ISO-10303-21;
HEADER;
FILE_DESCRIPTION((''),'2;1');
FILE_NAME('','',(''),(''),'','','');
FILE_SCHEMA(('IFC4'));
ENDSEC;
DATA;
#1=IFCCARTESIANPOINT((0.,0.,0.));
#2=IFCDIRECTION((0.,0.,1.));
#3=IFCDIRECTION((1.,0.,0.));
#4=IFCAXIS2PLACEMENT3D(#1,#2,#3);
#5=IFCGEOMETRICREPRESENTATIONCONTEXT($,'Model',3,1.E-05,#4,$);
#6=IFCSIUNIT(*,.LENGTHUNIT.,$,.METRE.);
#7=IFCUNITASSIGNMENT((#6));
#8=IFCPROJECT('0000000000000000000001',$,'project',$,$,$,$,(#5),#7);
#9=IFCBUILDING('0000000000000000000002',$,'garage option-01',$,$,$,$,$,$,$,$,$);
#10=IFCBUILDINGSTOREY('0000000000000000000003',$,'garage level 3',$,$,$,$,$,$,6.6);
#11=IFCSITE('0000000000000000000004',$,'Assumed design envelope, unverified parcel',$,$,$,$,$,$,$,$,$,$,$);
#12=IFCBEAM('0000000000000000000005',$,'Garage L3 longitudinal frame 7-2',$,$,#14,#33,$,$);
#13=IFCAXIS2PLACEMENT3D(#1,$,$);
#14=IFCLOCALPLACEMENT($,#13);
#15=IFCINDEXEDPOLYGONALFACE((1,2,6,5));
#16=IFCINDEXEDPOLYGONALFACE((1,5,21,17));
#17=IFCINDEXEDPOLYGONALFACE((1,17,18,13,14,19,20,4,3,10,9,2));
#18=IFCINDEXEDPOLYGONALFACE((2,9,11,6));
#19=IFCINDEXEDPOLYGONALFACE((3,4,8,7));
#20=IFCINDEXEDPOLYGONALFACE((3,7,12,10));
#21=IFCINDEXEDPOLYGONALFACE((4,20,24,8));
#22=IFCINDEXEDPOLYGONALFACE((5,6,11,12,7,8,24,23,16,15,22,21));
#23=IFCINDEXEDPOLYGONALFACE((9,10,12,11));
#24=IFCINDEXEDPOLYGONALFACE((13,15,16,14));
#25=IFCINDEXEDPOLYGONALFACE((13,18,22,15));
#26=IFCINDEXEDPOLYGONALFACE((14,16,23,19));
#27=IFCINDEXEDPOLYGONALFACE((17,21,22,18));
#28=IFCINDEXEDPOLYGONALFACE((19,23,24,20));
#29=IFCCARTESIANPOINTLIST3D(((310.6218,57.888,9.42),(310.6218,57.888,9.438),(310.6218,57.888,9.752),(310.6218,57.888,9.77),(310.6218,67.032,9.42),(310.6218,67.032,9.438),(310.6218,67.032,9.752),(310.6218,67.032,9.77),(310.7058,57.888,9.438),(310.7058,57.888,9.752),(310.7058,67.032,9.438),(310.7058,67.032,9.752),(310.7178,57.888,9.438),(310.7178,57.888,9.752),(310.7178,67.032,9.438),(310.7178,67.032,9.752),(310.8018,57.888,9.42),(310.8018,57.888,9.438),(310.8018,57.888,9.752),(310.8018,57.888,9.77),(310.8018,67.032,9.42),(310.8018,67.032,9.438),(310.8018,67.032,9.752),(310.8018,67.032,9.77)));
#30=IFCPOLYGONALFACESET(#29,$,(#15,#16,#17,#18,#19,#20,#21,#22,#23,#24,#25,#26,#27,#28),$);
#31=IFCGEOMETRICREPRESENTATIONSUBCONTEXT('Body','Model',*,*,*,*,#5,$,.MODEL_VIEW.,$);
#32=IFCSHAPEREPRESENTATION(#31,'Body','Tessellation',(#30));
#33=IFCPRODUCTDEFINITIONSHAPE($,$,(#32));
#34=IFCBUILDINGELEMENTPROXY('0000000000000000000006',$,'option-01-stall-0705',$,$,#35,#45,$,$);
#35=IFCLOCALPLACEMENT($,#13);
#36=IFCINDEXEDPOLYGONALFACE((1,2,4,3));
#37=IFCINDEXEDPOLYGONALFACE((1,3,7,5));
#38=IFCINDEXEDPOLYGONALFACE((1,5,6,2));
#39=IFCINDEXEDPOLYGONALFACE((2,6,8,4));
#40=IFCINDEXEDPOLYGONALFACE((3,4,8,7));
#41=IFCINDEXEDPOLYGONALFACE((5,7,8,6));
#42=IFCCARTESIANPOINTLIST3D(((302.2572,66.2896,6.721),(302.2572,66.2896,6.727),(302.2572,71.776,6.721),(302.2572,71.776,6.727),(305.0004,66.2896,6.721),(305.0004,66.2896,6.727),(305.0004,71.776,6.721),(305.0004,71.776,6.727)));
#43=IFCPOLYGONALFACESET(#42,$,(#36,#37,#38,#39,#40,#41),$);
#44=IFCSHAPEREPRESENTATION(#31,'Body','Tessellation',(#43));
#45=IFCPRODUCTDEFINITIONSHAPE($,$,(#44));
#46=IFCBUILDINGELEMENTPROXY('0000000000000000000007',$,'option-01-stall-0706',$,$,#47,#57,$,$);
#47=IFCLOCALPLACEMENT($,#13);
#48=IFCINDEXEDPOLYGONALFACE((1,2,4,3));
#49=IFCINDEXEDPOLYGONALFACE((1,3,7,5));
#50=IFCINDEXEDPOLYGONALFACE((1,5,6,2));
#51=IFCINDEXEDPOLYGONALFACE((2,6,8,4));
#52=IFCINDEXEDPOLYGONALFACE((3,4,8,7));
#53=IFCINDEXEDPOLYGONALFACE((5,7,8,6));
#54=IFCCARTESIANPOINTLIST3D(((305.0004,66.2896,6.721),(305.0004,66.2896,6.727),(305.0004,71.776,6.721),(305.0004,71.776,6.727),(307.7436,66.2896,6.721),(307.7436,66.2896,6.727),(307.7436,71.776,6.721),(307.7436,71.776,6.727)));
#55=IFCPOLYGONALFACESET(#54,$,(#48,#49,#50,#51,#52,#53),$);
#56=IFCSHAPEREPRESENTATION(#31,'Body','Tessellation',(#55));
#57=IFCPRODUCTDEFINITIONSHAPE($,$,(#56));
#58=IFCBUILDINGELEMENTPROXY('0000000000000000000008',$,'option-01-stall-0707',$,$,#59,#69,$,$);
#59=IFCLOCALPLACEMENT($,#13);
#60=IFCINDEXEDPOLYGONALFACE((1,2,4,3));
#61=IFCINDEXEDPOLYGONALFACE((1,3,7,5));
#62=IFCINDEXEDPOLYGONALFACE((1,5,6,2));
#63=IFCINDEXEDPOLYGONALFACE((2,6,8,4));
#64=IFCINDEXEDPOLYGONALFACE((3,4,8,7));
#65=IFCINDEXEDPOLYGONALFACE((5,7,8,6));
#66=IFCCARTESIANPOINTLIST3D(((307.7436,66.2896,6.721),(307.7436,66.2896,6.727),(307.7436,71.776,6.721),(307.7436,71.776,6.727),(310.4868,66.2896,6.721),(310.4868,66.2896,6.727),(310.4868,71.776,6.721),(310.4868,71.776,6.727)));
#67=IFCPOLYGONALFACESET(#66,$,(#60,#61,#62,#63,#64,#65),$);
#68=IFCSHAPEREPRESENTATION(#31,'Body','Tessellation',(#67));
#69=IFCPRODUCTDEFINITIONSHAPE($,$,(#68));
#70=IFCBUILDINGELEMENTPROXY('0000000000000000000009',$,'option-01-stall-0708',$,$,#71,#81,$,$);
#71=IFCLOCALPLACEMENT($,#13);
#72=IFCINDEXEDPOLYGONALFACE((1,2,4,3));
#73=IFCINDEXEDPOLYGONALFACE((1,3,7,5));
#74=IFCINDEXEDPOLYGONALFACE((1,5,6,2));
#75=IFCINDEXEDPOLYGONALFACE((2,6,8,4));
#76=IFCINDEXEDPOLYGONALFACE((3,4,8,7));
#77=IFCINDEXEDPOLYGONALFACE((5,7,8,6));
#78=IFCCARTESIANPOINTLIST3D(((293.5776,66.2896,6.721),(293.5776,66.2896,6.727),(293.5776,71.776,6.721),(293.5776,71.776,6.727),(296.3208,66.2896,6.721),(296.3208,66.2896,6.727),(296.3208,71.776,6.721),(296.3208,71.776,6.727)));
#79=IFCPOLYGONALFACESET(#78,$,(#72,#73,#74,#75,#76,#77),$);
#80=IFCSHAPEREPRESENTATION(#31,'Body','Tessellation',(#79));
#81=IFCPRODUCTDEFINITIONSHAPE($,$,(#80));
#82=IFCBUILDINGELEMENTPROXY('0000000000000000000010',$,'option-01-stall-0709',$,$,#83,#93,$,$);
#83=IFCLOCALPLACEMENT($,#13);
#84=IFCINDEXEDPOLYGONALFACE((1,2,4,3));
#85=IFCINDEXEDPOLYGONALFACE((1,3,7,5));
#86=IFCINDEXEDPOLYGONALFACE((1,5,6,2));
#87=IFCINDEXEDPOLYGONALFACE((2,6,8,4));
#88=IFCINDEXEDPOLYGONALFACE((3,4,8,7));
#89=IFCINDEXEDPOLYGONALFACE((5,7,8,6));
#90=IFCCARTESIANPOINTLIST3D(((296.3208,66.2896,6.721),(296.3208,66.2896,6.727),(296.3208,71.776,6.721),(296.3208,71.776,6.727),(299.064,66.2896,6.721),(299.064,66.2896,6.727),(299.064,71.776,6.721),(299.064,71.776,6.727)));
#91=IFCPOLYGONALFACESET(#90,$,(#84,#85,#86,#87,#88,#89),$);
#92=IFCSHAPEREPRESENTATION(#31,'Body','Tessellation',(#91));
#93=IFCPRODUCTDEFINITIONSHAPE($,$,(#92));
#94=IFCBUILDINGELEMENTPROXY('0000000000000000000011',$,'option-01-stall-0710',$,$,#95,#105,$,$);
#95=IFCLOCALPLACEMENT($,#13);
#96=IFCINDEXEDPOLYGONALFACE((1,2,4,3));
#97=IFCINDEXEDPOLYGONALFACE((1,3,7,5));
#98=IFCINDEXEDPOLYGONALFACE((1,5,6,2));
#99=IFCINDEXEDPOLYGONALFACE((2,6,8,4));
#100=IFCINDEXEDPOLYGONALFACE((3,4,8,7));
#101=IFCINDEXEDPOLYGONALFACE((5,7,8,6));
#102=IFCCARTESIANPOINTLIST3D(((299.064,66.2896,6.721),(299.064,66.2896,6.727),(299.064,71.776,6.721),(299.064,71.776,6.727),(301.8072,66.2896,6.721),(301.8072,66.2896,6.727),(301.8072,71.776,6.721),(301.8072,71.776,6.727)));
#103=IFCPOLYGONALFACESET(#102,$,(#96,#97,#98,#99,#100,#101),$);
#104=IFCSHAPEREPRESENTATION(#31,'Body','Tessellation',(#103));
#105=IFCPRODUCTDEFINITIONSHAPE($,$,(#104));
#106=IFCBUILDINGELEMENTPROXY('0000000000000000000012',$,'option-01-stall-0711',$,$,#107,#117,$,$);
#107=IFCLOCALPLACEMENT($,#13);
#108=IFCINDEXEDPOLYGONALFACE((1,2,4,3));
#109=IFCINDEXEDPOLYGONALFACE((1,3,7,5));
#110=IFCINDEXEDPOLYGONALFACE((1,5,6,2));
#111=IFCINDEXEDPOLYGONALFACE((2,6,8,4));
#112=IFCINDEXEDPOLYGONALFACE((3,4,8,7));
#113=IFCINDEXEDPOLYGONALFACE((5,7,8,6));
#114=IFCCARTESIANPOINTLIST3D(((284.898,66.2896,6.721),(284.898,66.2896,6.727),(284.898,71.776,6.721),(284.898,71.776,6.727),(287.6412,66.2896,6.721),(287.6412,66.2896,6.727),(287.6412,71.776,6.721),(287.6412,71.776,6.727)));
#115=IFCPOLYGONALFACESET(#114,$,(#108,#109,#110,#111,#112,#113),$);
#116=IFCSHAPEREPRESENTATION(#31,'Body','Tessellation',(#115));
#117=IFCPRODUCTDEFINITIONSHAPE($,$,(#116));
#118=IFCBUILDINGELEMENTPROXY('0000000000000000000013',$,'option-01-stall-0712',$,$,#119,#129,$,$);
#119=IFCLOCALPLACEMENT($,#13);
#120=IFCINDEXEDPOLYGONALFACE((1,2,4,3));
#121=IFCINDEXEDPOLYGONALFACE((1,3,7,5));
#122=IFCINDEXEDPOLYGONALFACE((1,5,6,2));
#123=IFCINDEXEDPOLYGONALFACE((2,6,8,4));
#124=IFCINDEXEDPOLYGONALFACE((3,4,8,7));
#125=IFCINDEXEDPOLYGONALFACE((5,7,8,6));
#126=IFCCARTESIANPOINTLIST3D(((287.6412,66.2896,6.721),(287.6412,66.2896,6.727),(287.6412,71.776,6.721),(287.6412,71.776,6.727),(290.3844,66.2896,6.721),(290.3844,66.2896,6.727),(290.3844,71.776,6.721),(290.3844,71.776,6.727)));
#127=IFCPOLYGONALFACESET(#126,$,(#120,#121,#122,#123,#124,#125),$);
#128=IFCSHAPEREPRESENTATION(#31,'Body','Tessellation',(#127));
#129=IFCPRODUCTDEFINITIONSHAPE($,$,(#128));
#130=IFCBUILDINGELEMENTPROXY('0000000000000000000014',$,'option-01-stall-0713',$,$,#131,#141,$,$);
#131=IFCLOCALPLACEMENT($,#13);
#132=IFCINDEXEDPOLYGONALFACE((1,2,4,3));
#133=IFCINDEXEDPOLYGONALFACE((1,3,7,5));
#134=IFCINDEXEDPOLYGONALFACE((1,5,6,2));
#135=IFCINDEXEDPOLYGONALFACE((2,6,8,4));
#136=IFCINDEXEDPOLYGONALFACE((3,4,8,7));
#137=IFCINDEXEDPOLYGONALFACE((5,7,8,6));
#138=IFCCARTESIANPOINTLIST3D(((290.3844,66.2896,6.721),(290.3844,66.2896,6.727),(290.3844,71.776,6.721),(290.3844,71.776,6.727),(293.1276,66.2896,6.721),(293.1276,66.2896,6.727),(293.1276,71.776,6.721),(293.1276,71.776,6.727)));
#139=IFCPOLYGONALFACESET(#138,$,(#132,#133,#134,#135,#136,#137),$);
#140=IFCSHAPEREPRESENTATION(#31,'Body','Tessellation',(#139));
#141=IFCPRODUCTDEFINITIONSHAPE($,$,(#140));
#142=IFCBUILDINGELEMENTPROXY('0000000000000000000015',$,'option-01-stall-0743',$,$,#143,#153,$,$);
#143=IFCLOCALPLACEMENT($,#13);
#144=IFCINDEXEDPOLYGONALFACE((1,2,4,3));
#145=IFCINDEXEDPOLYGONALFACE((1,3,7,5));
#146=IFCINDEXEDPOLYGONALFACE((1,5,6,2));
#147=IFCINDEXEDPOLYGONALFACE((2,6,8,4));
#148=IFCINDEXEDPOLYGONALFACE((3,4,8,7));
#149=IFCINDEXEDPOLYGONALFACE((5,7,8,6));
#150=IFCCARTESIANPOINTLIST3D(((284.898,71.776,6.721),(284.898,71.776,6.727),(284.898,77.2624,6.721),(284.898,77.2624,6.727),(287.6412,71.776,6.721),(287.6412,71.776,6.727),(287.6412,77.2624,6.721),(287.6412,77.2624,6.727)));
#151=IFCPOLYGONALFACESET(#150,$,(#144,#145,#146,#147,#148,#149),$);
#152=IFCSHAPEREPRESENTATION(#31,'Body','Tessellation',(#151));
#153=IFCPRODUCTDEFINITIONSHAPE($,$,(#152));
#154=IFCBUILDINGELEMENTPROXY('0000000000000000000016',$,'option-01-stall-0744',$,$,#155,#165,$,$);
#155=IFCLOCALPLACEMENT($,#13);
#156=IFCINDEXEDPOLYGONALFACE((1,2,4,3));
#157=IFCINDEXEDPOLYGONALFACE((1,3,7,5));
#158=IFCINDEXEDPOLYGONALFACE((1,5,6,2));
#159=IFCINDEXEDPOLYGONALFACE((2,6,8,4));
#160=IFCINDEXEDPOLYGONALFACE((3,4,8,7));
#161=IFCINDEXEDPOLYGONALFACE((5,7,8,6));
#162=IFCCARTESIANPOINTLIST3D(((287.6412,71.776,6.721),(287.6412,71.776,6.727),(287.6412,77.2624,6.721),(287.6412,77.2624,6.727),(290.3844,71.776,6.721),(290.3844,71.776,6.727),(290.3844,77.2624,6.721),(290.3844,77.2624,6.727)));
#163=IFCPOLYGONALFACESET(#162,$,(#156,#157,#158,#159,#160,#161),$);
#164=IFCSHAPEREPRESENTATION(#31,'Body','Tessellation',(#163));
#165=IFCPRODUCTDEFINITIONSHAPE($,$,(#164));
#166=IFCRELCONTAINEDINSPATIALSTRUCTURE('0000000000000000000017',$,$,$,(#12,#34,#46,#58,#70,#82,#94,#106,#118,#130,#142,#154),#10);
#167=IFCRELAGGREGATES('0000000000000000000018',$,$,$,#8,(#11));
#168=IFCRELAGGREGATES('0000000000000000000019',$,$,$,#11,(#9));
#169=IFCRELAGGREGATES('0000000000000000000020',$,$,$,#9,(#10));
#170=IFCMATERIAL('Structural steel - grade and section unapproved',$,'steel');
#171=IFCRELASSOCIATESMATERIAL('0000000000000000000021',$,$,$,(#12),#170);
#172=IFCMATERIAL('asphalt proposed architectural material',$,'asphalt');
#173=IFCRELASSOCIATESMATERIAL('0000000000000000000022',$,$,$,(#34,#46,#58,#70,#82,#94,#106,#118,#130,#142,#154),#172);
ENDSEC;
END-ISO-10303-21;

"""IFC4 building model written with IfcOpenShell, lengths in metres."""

from ifc_helpers import new_model, si_unit, frame, origin_with_axes, place, context, subcontext, project, spatial, rectangle, i_section, extrude, material, element, save


model = new_model("IFC4")

# Units and contexts
model_context = context("Model", 3, precision=1e-05, world=origin_with_axes())
body_context = subcontext(model_context, "Body", "Model", "MODEL_VIEW")
ifc_project = project(units=[si_unit("LENGTHUNIT", "METRE")], contexts=[model_context])

# Site, building, storey
site = spatial("IfcSite", under=ifc_project, Name="Assumed design envelope, unverified parcel")
building = spatial("IfcBuilding", under=site, Name="garage option-01")
storey = spatial("IfcBuildingStorey", under=building, Name="garage level 3", Elevation=6.6)

# Beam
ifc_material_1 = material(Name="Structural steel - grade and section unapproved", Category="steel")
beam_1_placement = place(None, frame((310.7118, 57.888, 9.595), z_axis=(0.0, 1.0, 0.0), x_axis=(-1.0, 0.0, 0.0)))
element("IfcBeam", 1, at=beam_1_placement, inside=storey, material=ifc_material_1, Name="Garage L3 longitudinal frame 7-2", context=body_context, shape_type="SweptSolid", body=[
    extrude(i_section(OverallWidth=0.18, OverallDepth=0.35, WebThickness=0.012, FlangeThickness=0.018, FilletRadius=0.0), origin_with_axes(), (0.0, 0.0, 1.0), 9.144),
])

# Building element proxies
ifc_material_2 = material(Name="asphalt proposed architectural material", Category="asphalt")
for number, where, z_axis, x_axis, name in (
    (2, (303.6288, 69.0328, 6.721), (0.0, 0.0, 1.0), (1.0, 0.0, 0.0), "option-01-stall-0705"),
    (3, (306.372, 69.0328, 6.721), (0.0, 0.0, 1.0), (1.0, 0.0, 0.0), "option-01-stall-0706"),
    (4, (309.1152, 69.0328, 6.721), (0.0, 0.0, 1.0), (1.0, 0.0, 0.0), "option-01-stall-0707"),
    (5, (294.9492, 69.0328, 6.721), (0.0, 0.0, 1.0), (1.0, 0.0, 0.0), "option-01-stall-0708"),
    (6, (297.6924, 69.0328, 6.721), (0.0, 0.0, 1.0), (1.0, 0.0, 0.0), "option-01-stall-0709"),
    (7, (300.4356, 69.0328, 6.721), (0.0, 0.0, 1.0), (1.0, 0.0, 0.0), "option-01-stall-0710"),
    (8, (286.2696, 69.0328, 6.721), (0.0, 0.0, 1.0), (1.0, 0.0, 0.0), "option-01-stall-0711"),
    (9, (289.0128, 69.0328, 6.721), (0.0, 0.0, 1.0), (1.0, 0.0, 0.0), "option-01-stall-0712"),
    (10, (291.756, 69.0328, 6.721), (0.0, 0.0, 1.0), (1.0, 0.0, 0.0), "option-01-stall-0713"),
    (11, (286.2696, 74.5192, 6.721), (0.0, 0.0, 1.0), (1.0, 0.0, 0.0), "option-01-stall-0743"),
    (12, (289.0128, 74.5192, 6.721), (0.0, 0.0, 1.0), (1.0, 0.0, 0.0), "option-01-stall-0744"),
):
    element("IfcBuildingElementProxy", number, at=place(None, frame(where, z_axis=z_axis, x_axis=x_axis)), inside=storey, material=ifc_material_2, Name=name, context=body_context, shape_type="SweptSolid", body=[
        extrude(rectangle(XDim=2.7432, YDim=5.4864), origin_with_axes(), (0.0, 0.0, 1.0), 0.006),
    ])

save(model, "model.ifc")
